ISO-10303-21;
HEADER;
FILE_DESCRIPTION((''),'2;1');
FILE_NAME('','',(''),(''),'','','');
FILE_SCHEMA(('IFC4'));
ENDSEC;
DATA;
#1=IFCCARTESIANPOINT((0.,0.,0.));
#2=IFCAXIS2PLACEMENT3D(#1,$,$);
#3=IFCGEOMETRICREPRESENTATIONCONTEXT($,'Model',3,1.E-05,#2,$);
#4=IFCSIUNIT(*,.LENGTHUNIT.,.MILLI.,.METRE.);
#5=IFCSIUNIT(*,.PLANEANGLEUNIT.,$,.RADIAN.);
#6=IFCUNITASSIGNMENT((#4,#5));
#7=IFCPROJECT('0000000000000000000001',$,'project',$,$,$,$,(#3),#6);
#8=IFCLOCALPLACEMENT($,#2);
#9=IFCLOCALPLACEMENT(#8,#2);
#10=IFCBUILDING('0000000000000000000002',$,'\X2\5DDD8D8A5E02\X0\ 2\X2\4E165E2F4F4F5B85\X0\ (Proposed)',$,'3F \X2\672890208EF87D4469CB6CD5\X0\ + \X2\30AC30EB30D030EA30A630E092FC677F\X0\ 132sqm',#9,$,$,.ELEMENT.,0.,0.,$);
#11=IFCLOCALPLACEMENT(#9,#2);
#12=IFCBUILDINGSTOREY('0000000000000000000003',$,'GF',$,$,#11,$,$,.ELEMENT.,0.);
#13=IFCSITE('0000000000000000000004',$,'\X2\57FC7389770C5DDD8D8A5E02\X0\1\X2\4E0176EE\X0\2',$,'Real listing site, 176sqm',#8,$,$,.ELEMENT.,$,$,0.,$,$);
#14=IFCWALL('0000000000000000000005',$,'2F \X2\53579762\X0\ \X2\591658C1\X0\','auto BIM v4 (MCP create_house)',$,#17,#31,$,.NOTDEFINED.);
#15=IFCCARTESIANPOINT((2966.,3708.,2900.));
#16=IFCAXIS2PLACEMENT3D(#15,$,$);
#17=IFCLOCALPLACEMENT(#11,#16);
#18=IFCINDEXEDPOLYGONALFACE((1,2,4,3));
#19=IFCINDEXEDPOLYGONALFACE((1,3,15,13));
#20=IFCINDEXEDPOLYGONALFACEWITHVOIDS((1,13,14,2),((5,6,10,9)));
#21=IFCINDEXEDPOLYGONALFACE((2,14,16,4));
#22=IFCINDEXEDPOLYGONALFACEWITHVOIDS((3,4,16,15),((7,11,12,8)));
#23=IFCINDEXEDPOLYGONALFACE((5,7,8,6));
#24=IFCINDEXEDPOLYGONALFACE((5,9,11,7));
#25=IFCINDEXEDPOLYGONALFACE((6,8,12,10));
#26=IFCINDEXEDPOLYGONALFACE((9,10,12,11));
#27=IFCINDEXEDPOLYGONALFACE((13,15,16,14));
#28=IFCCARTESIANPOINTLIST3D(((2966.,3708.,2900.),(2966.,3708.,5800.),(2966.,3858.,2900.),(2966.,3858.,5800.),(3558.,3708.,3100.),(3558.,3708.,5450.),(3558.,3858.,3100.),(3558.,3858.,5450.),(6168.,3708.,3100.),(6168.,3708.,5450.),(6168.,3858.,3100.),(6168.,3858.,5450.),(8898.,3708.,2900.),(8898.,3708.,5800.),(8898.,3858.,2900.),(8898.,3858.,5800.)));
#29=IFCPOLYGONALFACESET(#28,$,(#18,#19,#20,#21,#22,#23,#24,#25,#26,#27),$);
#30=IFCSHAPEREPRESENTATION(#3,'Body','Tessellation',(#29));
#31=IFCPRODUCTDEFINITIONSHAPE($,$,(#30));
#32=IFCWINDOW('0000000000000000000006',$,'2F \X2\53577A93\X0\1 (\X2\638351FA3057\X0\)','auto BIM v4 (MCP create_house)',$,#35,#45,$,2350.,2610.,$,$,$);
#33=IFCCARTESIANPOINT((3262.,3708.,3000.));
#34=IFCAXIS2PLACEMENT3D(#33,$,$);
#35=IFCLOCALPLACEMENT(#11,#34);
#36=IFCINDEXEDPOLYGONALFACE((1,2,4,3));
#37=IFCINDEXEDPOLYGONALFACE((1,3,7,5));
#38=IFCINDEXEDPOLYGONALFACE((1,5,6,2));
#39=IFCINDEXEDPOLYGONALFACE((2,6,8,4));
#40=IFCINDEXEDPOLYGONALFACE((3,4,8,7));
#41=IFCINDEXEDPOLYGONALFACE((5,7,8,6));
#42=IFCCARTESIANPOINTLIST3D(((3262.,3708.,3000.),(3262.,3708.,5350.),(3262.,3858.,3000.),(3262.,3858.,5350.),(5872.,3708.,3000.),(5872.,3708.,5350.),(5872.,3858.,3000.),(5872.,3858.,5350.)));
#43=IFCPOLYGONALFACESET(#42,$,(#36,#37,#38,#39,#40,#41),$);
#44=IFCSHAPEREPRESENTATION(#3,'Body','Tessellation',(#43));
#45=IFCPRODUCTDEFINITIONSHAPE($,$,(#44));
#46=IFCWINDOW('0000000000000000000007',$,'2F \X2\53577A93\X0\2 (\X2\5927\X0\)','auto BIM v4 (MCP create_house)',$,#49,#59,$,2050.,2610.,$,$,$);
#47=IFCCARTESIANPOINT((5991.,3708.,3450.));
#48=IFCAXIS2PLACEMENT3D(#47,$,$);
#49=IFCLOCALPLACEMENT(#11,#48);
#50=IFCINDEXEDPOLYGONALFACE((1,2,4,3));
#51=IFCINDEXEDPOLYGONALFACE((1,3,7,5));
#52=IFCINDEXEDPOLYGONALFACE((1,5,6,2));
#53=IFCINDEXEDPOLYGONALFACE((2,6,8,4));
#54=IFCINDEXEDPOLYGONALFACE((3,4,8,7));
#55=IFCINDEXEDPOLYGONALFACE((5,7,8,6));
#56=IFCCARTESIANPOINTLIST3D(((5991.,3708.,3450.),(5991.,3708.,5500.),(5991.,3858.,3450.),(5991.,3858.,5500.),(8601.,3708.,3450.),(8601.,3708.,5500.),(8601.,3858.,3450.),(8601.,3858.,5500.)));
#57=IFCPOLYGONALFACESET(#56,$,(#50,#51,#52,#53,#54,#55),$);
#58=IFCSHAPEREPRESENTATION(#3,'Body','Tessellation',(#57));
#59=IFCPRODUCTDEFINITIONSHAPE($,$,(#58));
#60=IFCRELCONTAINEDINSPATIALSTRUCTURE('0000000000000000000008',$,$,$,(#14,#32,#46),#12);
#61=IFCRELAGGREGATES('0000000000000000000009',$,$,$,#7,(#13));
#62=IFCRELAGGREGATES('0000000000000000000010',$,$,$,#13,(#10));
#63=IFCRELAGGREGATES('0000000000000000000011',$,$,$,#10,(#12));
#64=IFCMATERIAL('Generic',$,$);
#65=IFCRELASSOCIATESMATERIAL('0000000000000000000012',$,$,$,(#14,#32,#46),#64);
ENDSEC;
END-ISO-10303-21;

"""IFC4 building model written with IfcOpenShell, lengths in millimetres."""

from ifc_helpers import new_model, si_unit, frame, frame_2d, origin, place, context, project, spatial, rectangle, extrude, material, element, fill, save


model = new_model("IFC4")

# Units and contexts
model_context = context("Model", 3, precision=1e-05, world=origin())
ifc_project = project(units=[si_unit("LENGTHUNIT", "METRE", prefix="MILLI"), si_unit("PLANEANGLEUNIT", "RADIAN")], contexts=[model_context])

# Site, building, storey
site_placement = place(None, origin())
site = spatial("IfcSite", under=ifc_project, at=site_placement, Name="埼玉県川越市1丁目2", ObjectType="Real listing site, 176sqm", CompositionType="ELEMENT", RefElevation=0.0)
building_placement = place(site_placement, origin())
building = spatial("IfcBuilding", under=site, at=building_placement, Name="川越市 2世帯住宅 (Proposed)", ObjectType="3F 木造軸組構法 + ガルバリウム鋼板 132sqm", CompositionType="ELEMENT", ElevationOfRefHeight=0.0, ElevationOfTerrain=0.0)
storey_placement = place(building_placement, origin())
storey = spatial("IfcBuildingStorey", under=building, at=storey_placement, Name="GF", CompositionType="ELEMENT", Elevation=0.0)

# Shared definitions
ifc_material = material(Name="Generic")

# Wall, openings, windows
wall_1_placement = place(storey_placement, frame((2966.0, 3708.0, 2900.0)))
wall_1 = element("IfcWall", 1, at=wall_1_placement, inside=storey, material=ifc_material, Name="2F 南面 外壁", Description="auto BIM v4 (MCP create_house)", PredefinedType="NOTDEFINED", context=model_context, shape_type="SweptSolid", body=[
    extrude(rectangle(XDim=5932.0, YDim=150.0, at=frame_2d((2966.0, 75.0))), frame((2966.0, 3708.0, 2900.0)), (0.0, 0.0, 1.0), 2900.0),
])
opening_1_placement = place(storey_placement, frame((3262.0, 3708.0, 3000.0)))
opening_1 = element("IfcOpeningElement", 2, at=opening_1_placement, cuts=wall_1, PredefinedType="NOTDEFINED", context=model_context, shape_type="SweptSolid", body=[
    extrude(rectangle(XDim=2610.0, YDim=150.0, at=frame_2d((1305.0, 75.0))), frame((3262.0, 3708.0, 3000.0)), (0.0, 0.0, 1.0), 2350.0),
])
opening_2_placement = place(storey_placement, frame((5991.0, 3708.0, 3450.0)))
opening_2 = element("IfcOpeningElement", 3, at=opening_2_placement, cuts=wall_1, PredefinedType="NOTDEFINED", context=model_context, shape_type="SweptSolid", body=[
    extrude(rectangle(XDim=2610.0, YDim=150.0, at=frame_2d((1305.0, 75.0))), frame((5991.0, 3708.0, 3450.0)), (0.0, 0.0, 1.0), 2050.0),
])
window_1_placement = place(storey_placement, frame((3262.0, 3708.0, 3000.0)))
window_1 = element("IfcWindow", 4, at=window_1_placement, inside=storey, material=ifc_material, Name="2F 南窓1 (掃出し)", Description="auto BIM v4 (MCP create_house)", OverallHeight=2350.0, OverallWidth=2610.0, context=model_context, shape_type="SweptSolid", body=[
    extrude(rectangle(XDim=2610.0, YDim=150.0, at=frame_2d((1305.0, 75.0))), frame((3262.0, 3708.0, 3000.0)), (0.0, 0.0, 1.0), 2350.0),
])
fill(opening_1, window_1)
window_2_placement = place(storey_placement, frame((5991.0, 3708.0, 3450.0)))
window_2 = element("IfcWindow", 5, at=window_2_placement, inside=storey, material=ifc_material, Name="2F 南窓2 (大)", Description="auto BIM v4 (MCP create_house)", OverallHeight=2050.0, OverallWidth=2610.0, context=model_context, shape_type="SweptSolid", body=[
    extrude(rectangle(XDim=2610.0, YDim=150.0, at=frame_2d((1305.0, 75.0))), frame((5991.0, 3708.0, 3450.0)), (0.0, 0.0, 1.0), 2050.0),
])
fill(opening_2, window_2)

save(model, "model.ifc")
